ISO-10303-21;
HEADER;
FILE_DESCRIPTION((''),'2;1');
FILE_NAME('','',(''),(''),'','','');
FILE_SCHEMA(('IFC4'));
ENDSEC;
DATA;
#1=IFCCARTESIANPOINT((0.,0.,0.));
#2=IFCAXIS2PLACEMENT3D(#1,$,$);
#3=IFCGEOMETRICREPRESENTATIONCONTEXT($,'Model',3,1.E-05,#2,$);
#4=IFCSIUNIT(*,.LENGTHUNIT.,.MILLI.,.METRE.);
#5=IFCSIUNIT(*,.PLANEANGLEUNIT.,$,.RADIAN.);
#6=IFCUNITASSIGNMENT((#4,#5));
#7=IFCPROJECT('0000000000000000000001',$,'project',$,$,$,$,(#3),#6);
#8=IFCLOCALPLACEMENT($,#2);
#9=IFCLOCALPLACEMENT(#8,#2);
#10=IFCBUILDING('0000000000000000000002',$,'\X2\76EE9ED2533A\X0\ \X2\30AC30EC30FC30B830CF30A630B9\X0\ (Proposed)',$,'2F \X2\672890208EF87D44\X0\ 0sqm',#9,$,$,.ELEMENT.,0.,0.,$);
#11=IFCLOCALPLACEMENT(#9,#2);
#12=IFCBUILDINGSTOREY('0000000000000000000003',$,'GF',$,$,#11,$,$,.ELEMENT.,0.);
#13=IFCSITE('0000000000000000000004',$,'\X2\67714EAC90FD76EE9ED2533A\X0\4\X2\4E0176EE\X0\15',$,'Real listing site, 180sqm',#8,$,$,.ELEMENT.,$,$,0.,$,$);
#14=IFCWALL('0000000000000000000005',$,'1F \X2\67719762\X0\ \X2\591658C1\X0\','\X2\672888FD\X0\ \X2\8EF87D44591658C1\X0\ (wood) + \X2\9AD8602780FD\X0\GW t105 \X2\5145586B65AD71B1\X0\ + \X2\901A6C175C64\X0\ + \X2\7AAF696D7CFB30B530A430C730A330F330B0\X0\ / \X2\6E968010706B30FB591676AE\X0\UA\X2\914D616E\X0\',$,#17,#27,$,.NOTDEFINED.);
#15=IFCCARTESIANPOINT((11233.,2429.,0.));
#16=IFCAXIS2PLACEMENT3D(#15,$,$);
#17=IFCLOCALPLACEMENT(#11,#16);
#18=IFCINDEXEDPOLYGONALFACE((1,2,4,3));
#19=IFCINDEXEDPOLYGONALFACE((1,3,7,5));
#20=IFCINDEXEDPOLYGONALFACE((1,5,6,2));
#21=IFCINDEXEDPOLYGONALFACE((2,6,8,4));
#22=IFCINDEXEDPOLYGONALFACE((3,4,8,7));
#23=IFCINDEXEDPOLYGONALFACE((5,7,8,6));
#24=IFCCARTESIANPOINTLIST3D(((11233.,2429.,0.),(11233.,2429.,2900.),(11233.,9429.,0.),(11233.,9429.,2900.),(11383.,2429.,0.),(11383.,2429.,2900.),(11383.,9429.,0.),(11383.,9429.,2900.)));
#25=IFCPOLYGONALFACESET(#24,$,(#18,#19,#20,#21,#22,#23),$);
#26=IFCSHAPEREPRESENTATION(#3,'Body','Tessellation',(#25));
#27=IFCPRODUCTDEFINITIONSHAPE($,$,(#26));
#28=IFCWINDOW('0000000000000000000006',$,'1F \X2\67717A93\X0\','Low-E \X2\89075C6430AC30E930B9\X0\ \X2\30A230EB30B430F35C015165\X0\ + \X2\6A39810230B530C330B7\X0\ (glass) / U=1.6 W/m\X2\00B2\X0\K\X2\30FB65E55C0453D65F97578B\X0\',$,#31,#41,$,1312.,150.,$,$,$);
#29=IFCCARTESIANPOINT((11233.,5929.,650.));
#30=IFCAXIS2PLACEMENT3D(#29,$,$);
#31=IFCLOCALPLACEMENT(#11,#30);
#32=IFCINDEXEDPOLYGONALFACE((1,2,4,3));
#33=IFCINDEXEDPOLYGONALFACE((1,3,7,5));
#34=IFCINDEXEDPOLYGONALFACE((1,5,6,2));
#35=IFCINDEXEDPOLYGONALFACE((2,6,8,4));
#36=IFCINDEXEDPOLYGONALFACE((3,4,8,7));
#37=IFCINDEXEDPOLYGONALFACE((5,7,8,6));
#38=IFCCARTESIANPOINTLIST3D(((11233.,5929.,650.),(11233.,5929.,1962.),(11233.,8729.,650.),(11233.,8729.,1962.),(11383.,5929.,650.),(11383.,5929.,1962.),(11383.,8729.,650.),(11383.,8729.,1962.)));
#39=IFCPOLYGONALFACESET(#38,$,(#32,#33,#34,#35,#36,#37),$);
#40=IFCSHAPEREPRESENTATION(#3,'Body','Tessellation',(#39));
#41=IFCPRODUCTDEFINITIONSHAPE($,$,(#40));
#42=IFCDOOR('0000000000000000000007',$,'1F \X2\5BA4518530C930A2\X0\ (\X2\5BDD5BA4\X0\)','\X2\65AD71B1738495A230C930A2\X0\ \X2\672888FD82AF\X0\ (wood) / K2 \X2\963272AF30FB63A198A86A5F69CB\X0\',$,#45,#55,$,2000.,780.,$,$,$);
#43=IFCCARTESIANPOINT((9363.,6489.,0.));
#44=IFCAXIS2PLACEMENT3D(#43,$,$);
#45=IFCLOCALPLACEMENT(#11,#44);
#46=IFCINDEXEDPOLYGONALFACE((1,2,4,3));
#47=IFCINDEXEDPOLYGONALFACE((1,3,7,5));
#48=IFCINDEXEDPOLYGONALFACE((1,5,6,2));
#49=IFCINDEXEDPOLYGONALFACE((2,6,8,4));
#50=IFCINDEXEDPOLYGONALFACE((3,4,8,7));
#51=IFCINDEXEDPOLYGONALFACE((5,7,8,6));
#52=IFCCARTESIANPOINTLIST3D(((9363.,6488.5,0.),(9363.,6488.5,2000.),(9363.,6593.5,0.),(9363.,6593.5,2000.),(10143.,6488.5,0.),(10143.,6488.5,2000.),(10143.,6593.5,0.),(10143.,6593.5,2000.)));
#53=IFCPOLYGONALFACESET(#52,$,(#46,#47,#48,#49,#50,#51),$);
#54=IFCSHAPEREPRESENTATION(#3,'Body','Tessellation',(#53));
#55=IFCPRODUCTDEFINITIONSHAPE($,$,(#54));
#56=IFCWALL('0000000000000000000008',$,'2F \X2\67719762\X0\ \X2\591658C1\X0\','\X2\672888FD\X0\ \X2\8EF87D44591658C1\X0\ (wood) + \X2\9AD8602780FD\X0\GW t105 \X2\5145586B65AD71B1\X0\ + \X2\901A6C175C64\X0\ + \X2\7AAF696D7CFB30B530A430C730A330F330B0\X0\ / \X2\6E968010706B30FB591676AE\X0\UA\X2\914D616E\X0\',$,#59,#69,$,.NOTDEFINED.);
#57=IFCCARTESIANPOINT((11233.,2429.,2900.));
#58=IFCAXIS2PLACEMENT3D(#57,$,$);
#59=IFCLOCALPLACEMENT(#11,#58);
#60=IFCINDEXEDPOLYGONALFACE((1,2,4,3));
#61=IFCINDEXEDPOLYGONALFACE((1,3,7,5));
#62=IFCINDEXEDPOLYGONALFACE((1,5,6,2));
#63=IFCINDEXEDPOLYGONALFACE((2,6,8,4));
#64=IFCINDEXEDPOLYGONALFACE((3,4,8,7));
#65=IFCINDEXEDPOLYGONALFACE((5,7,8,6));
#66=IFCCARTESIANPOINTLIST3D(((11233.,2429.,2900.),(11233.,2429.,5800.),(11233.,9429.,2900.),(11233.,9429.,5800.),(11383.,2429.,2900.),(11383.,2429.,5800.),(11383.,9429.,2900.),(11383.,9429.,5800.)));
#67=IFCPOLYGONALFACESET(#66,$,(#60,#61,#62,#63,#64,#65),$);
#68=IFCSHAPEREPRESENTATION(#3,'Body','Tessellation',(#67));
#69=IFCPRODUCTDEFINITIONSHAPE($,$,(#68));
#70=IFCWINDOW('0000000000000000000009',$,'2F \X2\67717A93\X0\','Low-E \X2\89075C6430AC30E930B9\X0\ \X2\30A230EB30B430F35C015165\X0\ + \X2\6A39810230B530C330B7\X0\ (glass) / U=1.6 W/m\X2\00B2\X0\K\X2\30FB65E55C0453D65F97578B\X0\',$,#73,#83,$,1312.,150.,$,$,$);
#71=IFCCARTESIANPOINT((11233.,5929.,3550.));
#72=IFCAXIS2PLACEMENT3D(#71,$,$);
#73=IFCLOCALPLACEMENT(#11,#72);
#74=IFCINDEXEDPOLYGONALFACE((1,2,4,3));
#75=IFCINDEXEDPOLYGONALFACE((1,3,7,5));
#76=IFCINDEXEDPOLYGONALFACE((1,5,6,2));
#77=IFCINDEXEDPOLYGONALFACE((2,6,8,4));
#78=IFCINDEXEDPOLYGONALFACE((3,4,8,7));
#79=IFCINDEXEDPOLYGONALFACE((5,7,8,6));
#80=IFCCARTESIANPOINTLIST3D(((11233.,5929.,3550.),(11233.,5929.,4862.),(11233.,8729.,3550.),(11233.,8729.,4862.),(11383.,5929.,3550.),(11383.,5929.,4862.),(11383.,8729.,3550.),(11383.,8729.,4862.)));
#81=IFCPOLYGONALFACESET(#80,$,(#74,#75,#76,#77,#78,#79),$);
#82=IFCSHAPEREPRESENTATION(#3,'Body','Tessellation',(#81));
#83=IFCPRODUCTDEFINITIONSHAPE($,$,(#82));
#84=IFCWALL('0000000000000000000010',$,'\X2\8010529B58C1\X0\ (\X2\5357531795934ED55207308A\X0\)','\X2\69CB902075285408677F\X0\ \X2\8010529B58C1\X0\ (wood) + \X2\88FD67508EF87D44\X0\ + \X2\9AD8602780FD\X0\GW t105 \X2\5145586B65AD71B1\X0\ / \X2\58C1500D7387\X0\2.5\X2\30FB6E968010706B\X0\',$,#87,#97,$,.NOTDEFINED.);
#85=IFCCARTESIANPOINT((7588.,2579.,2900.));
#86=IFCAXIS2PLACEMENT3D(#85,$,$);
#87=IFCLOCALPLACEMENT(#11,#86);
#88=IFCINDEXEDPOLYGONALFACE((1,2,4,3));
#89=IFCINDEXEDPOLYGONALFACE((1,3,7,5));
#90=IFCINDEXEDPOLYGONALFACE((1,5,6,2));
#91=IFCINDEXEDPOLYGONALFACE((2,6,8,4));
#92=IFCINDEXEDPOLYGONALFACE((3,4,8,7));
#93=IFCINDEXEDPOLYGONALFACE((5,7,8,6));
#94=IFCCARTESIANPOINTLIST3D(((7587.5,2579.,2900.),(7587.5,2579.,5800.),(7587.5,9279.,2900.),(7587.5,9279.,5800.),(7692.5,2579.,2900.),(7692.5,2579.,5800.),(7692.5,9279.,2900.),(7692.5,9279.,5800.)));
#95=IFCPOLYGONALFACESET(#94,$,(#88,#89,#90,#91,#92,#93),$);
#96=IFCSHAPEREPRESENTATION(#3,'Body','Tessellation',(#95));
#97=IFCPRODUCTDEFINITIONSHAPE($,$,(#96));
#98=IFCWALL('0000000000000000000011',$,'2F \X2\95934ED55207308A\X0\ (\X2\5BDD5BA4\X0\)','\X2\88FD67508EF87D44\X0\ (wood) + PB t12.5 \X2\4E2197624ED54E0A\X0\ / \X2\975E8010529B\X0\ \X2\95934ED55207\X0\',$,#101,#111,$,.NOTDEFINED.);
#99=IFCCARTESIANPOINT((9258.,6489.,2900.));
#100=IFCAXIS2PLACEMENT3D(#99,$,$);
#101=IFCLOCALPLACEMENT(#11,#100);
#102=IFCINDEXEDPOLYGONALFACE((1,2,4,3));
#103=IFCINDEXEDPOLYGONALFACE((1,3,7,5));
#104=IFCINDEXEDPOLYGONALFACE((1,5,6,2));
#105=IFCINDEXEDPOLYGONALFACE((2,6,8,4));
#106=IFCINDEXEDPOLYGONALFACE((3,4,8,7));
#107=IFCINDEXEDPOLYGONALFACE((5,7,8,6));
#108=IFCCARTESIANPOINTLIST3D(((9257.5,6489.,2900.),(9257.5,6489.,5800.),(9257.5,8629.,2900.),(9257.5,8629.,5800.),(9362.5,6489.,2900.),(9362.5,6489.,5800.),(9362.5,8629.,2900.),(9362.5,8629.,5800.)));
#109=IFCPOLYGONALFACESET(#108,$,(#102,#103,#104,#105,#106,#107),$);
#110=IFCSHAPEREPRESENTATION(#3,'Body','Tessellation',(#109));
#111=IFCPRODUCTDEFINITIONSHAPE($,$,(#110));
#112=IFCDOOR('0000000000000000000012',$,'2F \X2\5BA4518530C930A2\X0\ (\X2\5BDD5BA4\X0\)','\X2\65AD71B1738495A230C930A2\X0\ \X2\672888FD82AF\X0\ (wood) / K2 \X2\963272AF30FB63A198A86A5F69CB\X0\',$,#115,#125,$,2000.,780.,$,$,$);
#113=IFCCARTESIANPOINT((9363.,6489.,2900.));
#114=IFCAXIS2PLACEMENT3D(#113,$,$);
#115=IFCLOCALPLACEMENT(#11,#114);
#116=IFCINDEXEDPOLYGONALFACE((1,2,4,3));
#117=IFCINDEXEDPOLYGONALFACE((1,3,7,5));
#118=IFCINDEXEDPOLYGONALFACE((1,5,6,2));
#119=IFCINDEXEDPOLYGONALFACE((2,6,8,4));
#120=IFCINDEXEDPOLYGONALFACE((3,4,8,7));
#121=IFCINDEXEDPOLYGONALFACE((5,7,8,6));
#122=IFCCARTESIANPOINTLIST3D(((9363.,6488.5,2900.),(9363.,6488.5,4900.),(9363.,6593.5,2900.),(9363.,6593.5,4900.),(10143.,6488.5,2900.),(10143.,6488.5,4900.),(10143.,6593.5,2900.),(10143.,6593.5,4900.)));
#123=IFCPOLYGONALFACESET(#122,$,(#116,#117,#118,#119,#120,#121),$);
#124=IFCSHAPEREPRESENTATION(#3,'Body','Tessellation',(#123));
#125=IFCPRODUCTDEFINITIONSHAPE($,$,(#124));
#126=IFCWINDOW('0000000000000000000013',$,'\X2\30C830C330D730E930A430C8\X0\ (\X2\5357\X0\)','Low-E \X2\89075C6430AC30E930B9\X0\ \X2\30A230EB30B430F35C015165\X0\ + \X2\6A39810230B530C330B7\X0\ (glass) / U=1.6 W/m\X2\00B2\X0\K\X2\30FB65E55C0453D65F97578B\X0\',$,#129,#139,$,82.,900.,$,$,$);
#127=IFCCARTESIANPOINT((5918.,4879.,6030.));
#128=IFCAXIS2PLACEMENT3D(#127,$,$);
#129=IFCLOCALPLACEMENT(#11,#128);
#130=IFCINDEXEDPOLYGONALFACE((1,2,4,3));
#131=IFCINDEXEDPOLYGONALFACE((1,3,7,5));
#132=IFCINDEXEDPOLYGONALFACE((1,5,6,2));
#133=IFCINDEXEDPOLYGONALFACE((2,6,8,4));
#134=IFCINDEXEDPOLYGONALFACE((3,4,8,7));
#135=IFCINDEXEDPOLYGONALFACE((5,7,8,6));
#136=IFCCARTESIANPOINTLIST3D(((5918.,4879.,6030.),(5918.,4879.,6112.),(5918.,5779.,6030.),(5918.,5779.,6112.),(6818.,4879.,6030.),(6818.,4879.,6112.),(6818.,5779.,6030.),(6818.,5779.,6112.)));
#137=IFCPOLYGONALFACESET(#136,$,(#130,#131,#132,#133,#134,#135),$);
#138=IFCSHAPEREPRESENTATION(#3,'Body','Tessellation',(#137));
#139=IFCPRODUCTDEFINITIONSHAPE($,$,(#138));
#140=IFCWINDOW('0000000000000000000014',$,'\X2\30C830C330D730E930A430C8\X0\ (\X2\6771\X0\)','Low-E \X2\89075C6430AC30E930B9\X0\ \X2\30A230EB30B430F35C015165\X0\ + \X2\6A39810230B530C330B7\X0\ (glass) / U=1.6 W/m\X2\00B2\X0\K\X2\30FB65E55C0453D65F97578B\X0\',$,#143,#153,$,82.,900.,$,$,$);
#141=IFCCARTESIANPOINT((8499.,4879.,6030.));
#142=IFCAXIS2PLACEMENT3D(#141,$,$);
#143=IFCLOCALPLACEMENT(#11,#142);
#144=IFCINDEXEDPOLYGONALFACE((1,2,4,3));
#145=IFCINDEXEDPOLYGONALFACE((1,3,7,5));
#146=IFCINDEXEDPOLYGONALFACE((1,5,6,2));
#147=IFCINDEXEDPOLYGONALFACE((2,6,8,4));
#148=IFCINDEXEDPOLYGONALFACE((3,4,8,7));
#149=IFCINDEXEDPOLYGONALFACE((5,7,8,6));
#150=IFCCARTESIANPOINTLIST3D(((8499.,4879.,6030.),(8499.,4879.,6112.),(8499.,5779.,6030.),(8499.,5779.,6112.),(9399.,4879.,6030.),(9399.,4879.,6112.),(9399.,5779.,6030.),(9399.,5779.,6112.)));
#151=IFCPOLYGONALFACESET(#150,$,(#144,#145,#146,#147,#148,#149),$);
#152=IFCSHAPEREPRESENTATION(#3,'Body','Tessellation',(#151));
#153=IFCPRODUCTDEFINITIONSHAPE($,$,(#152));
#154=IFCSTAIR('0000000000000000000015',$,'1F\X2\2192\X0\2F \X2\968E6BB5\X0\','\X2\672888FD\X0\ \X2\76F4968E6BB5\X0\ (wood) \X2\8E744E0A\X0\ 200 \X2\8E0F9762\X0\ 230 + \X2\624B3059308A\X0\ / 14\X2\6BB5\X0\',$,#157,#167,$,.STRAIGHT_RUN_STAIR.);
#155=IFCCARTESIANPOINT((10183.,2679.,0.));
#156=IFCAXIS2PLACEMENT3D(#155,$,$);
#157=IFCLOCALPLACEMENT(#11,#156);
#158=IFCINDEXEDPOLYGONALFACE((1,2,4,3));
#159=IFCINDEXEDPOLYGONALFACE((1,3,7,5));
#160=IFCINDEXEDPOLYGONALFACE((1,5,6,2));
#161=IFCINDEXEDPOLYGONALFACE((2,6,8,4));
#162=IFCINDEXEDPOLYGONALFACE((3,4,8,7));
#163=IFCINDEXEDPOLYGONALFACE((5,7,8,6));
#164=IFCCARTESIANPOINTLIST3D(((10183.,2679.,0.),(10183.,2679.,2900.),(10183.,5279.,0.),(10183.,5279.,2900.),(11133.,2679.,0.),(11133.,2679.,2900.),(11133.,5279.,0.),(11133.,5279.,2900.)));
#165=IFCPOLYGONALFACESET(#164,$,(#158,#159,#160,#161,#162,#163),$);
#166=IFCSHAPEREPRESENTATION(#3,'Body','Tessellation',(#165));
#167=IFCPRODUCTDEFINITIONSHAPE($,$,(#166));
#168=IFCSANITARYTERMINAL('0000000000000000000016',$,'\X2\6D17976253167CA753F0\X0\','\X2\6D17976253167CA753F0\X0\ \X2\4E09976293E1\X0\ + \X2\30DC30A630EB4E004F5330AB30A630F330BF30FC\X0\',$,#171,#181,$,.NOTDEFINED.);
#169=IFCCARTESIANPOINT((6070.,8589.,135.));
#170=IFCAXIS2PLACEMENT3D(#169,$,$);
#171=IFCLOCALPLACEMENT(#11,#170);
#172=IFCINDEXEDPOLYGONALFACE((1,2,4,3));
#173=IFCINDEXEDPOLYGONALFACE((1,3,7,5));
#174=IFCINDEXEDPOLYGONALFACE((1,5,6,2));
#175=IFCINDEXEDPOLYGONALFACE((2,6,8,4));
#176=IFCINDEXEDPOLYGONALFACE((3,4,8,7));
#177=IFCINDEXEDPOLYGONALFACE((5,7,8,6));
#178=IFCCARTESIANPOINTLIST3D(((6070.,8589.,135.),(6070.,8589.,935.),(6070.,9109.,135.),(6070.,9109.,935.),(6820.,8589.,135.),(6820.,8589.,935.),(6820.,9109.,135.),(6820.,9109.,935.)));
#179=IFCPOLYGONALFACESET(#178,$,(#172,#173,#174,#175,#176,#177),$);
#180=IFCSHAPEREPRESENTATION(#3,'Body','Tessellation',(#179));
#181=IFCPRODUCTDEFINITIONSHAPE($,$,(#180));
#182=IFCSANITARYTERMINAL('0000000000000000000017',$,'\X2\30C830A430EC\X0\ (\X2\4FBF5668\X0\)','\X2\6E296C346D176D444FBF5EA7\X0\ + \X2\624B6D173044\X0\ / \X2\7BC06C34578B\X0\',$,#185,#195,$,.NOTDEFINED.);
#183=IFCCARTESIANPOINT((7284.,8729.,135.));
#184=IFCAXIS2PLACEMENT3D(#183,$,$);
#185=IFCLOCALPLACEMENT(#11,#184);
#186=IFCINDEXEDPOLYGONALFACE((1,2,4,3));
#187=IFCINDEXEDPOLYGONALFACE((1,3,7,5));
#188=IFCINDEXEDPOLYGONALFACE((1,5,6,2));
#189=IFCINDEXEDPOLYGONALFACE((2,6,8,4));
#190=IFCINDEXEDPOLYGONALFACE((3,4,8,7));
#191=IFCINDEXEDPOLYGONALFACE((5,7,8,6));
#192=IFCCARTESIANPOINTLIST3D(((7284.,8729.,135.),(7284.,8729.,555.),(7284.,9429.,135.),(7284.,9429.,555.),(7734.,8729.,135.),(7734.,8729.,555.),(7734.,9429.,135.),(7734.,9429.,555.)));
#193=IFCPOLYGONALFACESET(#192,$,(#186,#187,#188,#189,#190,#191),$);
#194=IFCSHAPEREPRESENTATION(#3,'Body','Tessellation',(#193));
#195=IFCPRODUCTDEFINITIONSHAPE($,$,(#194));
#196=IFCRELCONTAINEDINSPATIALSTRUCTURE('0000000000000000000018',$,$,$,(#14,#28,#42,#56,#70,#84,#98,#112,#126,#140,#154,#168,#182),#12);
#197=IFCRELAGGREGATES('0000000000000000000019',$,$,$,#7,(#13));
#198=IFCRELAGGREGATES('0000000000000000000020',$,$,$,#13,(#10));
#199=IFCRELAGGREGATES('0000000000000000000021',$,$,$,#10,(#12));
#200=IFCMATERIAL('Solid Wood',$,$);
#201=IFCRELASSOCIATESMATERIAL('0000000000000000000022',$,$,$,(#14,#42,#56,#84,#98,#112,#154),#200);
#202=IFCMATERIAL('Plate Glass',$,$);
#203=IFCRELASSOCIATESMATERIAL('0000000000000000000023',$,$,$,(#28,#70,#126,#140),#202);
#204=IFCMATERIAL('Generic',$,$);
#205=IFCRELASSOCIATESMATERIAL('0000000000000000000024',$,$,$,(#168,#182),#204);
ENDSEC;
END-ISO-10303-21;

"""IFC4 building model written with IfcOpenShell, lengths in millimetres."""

from ifc_helpers import new_model, si_unit, frame, frame_2d, origin, place, context, project, spatial, rectangle, extrude, material, element, fill, save


model = new_model("IFC4")

# Units and contexts
model_context = context("Model", 3, precision=1e-05, world=origin())
ifc_project = project(units=[si_unit("LENGTHUNIT", "METRE", prefix="MILLI"), si_unit("PLANEANGLEUNIT", "RADIAN")], contexts=[model_context])

# Site, building, storey
site_placement = place(None, origin())
site = spatial("IfcSite", under=ifc_project, at=site_placement, Name="東京都目黒区4丁目15", ObjectType="Real listing site, 180sqm", CompositionType="ELEMENT", RefElevation=0.0)
building_placement = place(site_placement, origin())
building = spatial("IfcBuilding", under=site, at=building_placement, Name="目黒区 ガレージハウス (Proposed)", ObjectType="2F 木造軸組 0sqm", CompositionType="ELEMENT", ElevationOfRefHeight=0.0, ElevationOfTerrain=0.0)
storey_placement = place(building_placement, origin())
storey = spatial("IfcBuildingStorey", under=building, at=storey_placement, Name="GF", CompositionType="ELEMENT", Elevation=0.0)

# Wall, opening, window
ifc_material_1 = material(Name="Solid Wood")
wall_1_placement = place(storey_placement, frame((11233.0, 2429.0, 0.0)))
wall_1 = element("IfcWall", 1, at=wall_1_placement, inside=storey, material=ifc_material_1, Name="1F 東面 外壁", Description="木製 軸組外壁 (wood) + 高性能GW t105 充填断熱 + 通気層 + 窯業系サイディング / 準耐火・外皮UA配慮", PredefinedType="NOTDEFINED", context=model_context, shape_type="SweptSolid", body=[
    extrude(rectangle(XDim=150.0, YDim=7000.0, at=frame_2d((75.0, 3500.0))), frame((11233.0, 2429.0, 0.0)), (0.0, 0.0, 1.0), 2900.0),
])
opening_1_placement = place(storey_placement, frame((11233.0, 5929.0, 650.0)))
opening_1 = element("IfcOpeningElement", 2, at=opening_1_placement, cuts=wall_1, PredefinedType="NOTDEFINED", context=model_context, shape_type="SweptSolid", body=[
    extrude(rectangle(XDim=150.0, YDim=2800.0, at=frame_2d((75.0, 1400.0))), frame((11233.0, 5929.0, 650.0)), (0.0, 0.0, 1.0), 1312.0),
])
ifc_material_2 = material(Name="Plate Glass")
window_1_placement = place(storey_placement, frame((11233.0, 5929.0, 650.0)))
window_1 = element("IfcWindow", 3, at=window_1_placement, inside=storey, material=ifc_material_2, Name="1F 東窓", Description="Low-E 複層ガラス アルゴン封入 + 樹脂サッシ (glass) / U=1.6 W/m²K・日射取得型", OverallHeight=1312.0, OverallWidth=150.0, context=model_context, shape_type="SweptSolid", body=[
    extrude(rectangle(XDim=150.0, YDim=2800.0, at=frame_2d((75.0, 1400.0))), frame((11233.0, 5929.0, 650.0)), (0.0, 0.0, 1.0), 1312.0),
])
fill(opening_1, window_1)

# Door
door_1_placement = place(storey_placement, frame((9363.0, 6489.0, 0.0)))
element("IfcDoor", 4, at=door_1_placement, inside=storey, material=ifc_material_1, Name="1F 室内ドア (寝室)", Description="断熱玄関ドア 木製芯 (wood) / K2 防犯・採風機構", OverallHeight=2000.0, OverallWidth=780.0, context=model_context, shape_type="SweptSolid", body=[
    extrude(rectangle(XDim=780.0, YDim=105.0, at=frame_2d((390.0, 52.0))), frame((9363.0, 6489.0, 0.0)), (0.0, 0.0, 1.0), 2000.0),
])

# Wall, opening, window
wall_2_placement = place(storey_placement, frame((11233.0, 2429.0, 2900.0)))
wall_2 = element("IfcWall", 5, at=wall_2_placement, inside=storey, material=ifc_material_1, Name="2F 東面 外壁", Description="木製 軸組外壁 (wood) + 高性能GW t105 充填断熱 + 通気層 + 窯業系サイディング / 準耐火・外皮UA配慮", PredefinedType="NOTDEFINED", context=model_context, shape_type="SweptSolid", body=[
    extrude(rectangle(XDim=150.0, YDim=7000.0, at=frame_2d((75.0, 3500.0))), frame((11233.0, 2429.0, 2900.0)), (0.0, 0.0, 1.0), 2900.0),
])
opening_2_placement = place(storey_placement, frame((11233.0, 5929.0, 3550.0)))
opening_2 = element("IfcOpeningElement", 6, at=opening_2_placement, cuts=wall_2, PredefinedType="NOTDEFINED", context=model_context, shape_type="SweptSolid", body=[
    extrude(rectangle(XDim=150.0, YDim=2800.0, at=frame_2d((75.0, 1400.0))), frame((11233.0, 5929.0, 3550.0)), (0.0, 0.0, 1.0), 1312.0),
])
window_2_placement = place(storey_placement, frame((11233.0, 5929.0, 3550.0)))
window_2 = element("IfcWindow", 7, at=window_2_placement, inside=storey, material=ifc_material_2, Name="2F 東窓", Description="Low-E 複層ガラス アルゴン封入 + 樹脂サッシ (glass) / U=1.6 W/m²K・日射取得型", OverallHeight=1312.0, OverallWidth=150.0, context=model_context, shape_type="SweptSolid", body=[
    extrude(rectangle(XDim=150.0, YDim=2800.0, at=frame_2d((75.0, 1400.0))), frame((11233.0, 5929.0, 3550.0)), (0.0, 0.0, 1.0), 1312.0),
])
fill(opening_2, window_2)

# Walls
wall_3_placement = place(storey_placement, frame((7588.0, 2579.0, 2900.0)))
element("IfcWall", 8, at=wall_3_placement, inside=storey, material=ifc_material_1, Name="耐力壁 (南北間仕切り)", Description="構造用合板 耐力壁 (wood) + 製材軸組 + 高性能GW t105 充填断熱 / 壁倍率2.5・準耐火", PredefinedType="NOTDEFINED", context=model_context, shape_type="SweptSolid", body=[
    extrude(rectangle(XDim=105.0, YDim=6700.0, at=frame_2d((52.0, 3350.0))), frame((7588.0, 2579.0, 2900.0)), (0.0, 0.0, 1.0), 2900.0),
])
wall_4_placement = place(storey_placement, frame((9258.0, 6489.0, 2900.0)))
element("IfcWall", 9, at=wall_4_placement, inside=storey, material=ifc_material_1, Name="2F 間仕切り (寝室)", Description="製材軸組 (wood) + PB t12.5 両面仕上 / 非耐力 間仕切", PredefinedType="NOTDEFINED", context=model_context, shape_type="SweptSolid", body=[
    extrude(rectangle(XDim=105.0, YDim=2140.0, at=frame_2d((52.0, 1070.0))), frame((9258.0, 6489.0, 2900.0)), (0.0, 0.0, 1.0), 2900.0),
])

# Door
door_2_placement = place(storey_placement, frame((9363.0, 6489.0, 2900.0)))
element("IfcDoor", 10, at=door_2_placement, inside=storey, material=ifc_material_1, Name="2F 室内ドア (寝室)", Description="断熱玄関ドア 木製芯 (wood) / K2 防犯・採風機構", OverallHeight=2000.0, OverallWidth=780.0, context=model_context, shape_type="SweptSolid", body=[
    extrude(rectangle(XDim=780.0, YDim=105.0, at=frame_2d((390.0, 52.0))), frame((9363.0, 6489.0, 2900.0)), (0.0, 0.0, 1.0), 2000.0),
])

# Windows
window_3_placement = place(storey_placement, frame((5918.0, 4879.0, 6030.0)))
element("IfcWindow", 11, at=window_3_placement, inside=storey, material=ifc_material_2, Name="トップライト (南)", Description="Low-E 複層ガラス アルゴン封入 + 樹脂サッシ (glass) / U=1.6 W/m²K・日射取得型", OverallHeight=82.0, OverallWidth=900.0, context=model_context, shape_type="SweptSolid", body=[
    extrude(rectangle(XDim=900.0, YDim=900.0, at=frame_2d((450.0, 450.0))), frame((5918.0, 4879.0, 6030.0)), (0.0, 0.0, 1.0), 82.0),
])
window_4_placement = place(storey_placement, frame((8499.0, 4879.0, 6030.0)))
element("IfcWindow", 12, at=window_4_placement, inside=storey, material=ifc_material_2, Name="トップライト (東)", Description="Low-E 複層ガラス アルゴン封入 + 樹脂サッシ (glass) / U=1.6 W/m²K・日射取得型", OverallHeight=82.0, OverallWidth=900.0, context=model_context, shape_type="SweptSolid", body=[
    extrude(rectangle(XDim=900.0, YDim=900.0, at=frame_2d((450.0, 450.0))), frame((8499.0, 4879.0, 6030.0)), (0.0, 0.0, 1.0), 82.0),
])

# Stair
stair_placement = place(storey_placement, frame((10183.0, 2679.0, 0.0)))
element("IfcStair", 13, at=stair_placement, inside=storey, material=ifc_material_1, Name="1F→2F 階段", Description="木製 直階段 (wood) 蹴上 200 踏面 230 + 手すり / 14段", PredefinedType="STRAIGHT_RUN_STAIR", context=model_context, shape_type="SweptSolid", body=[
    extrude(rectangle(XDim=950.0, YDim=2600.0, at=frame_2d((475.0, 1300.0))), frame((10183.0, 2679.0, 0.0)), (0.0, 0.0, 1.0), 2900.0),
])

# Sanitary terminals
ifc_material_3 = material(Name="Generic")
sanitary_terminal_1_placement = place(storey_placement, frame((6070.0, 8589.0, 135.0)))
element("IfcSanitaryTerminal", 14, at=sanitary_terminal_1_placement, inside=storey, material=ifc_material_3, Name="洗面化粧台", Description="洗面化粧台 三面鏡 + ボウル一体カウンター", PredefinedType="NOTDEFINED", context=model_context, shape_type="SweptSolid", body=[
    extrude(rectangle(XDim=750.0, YDim=520.0, at=frame_2d((375.0, 260.0))), frame((6070.0, 8589.0, 135.0)), (0.0, 0.0, 1.0), 800.0),
])
sanitary_terminal_2_placement = place(storey_placement, frame((7284.0, 8729.0, 135.0)))
element("IfcSanitaryTerminal", 15, at=sanitary_terminal_2_placement, inside=storey, material=ifc_material_3, Name="トイレ (便器)", Description="温水洗浄便座 + 手洗い / 節水型", PredefinedType="NOTDEFINED", context=model_context, shape_type="SweptSolid", body=[
    extrude(rectangle(XDim=450.0, YDim=700.0, at=frame_2d((225.0, 350.0))), frame((7284.0, 8729.0, 135.0)), (0.0, 0.0, 1.0), 420.0),
])

save(model, "model.ifc")
